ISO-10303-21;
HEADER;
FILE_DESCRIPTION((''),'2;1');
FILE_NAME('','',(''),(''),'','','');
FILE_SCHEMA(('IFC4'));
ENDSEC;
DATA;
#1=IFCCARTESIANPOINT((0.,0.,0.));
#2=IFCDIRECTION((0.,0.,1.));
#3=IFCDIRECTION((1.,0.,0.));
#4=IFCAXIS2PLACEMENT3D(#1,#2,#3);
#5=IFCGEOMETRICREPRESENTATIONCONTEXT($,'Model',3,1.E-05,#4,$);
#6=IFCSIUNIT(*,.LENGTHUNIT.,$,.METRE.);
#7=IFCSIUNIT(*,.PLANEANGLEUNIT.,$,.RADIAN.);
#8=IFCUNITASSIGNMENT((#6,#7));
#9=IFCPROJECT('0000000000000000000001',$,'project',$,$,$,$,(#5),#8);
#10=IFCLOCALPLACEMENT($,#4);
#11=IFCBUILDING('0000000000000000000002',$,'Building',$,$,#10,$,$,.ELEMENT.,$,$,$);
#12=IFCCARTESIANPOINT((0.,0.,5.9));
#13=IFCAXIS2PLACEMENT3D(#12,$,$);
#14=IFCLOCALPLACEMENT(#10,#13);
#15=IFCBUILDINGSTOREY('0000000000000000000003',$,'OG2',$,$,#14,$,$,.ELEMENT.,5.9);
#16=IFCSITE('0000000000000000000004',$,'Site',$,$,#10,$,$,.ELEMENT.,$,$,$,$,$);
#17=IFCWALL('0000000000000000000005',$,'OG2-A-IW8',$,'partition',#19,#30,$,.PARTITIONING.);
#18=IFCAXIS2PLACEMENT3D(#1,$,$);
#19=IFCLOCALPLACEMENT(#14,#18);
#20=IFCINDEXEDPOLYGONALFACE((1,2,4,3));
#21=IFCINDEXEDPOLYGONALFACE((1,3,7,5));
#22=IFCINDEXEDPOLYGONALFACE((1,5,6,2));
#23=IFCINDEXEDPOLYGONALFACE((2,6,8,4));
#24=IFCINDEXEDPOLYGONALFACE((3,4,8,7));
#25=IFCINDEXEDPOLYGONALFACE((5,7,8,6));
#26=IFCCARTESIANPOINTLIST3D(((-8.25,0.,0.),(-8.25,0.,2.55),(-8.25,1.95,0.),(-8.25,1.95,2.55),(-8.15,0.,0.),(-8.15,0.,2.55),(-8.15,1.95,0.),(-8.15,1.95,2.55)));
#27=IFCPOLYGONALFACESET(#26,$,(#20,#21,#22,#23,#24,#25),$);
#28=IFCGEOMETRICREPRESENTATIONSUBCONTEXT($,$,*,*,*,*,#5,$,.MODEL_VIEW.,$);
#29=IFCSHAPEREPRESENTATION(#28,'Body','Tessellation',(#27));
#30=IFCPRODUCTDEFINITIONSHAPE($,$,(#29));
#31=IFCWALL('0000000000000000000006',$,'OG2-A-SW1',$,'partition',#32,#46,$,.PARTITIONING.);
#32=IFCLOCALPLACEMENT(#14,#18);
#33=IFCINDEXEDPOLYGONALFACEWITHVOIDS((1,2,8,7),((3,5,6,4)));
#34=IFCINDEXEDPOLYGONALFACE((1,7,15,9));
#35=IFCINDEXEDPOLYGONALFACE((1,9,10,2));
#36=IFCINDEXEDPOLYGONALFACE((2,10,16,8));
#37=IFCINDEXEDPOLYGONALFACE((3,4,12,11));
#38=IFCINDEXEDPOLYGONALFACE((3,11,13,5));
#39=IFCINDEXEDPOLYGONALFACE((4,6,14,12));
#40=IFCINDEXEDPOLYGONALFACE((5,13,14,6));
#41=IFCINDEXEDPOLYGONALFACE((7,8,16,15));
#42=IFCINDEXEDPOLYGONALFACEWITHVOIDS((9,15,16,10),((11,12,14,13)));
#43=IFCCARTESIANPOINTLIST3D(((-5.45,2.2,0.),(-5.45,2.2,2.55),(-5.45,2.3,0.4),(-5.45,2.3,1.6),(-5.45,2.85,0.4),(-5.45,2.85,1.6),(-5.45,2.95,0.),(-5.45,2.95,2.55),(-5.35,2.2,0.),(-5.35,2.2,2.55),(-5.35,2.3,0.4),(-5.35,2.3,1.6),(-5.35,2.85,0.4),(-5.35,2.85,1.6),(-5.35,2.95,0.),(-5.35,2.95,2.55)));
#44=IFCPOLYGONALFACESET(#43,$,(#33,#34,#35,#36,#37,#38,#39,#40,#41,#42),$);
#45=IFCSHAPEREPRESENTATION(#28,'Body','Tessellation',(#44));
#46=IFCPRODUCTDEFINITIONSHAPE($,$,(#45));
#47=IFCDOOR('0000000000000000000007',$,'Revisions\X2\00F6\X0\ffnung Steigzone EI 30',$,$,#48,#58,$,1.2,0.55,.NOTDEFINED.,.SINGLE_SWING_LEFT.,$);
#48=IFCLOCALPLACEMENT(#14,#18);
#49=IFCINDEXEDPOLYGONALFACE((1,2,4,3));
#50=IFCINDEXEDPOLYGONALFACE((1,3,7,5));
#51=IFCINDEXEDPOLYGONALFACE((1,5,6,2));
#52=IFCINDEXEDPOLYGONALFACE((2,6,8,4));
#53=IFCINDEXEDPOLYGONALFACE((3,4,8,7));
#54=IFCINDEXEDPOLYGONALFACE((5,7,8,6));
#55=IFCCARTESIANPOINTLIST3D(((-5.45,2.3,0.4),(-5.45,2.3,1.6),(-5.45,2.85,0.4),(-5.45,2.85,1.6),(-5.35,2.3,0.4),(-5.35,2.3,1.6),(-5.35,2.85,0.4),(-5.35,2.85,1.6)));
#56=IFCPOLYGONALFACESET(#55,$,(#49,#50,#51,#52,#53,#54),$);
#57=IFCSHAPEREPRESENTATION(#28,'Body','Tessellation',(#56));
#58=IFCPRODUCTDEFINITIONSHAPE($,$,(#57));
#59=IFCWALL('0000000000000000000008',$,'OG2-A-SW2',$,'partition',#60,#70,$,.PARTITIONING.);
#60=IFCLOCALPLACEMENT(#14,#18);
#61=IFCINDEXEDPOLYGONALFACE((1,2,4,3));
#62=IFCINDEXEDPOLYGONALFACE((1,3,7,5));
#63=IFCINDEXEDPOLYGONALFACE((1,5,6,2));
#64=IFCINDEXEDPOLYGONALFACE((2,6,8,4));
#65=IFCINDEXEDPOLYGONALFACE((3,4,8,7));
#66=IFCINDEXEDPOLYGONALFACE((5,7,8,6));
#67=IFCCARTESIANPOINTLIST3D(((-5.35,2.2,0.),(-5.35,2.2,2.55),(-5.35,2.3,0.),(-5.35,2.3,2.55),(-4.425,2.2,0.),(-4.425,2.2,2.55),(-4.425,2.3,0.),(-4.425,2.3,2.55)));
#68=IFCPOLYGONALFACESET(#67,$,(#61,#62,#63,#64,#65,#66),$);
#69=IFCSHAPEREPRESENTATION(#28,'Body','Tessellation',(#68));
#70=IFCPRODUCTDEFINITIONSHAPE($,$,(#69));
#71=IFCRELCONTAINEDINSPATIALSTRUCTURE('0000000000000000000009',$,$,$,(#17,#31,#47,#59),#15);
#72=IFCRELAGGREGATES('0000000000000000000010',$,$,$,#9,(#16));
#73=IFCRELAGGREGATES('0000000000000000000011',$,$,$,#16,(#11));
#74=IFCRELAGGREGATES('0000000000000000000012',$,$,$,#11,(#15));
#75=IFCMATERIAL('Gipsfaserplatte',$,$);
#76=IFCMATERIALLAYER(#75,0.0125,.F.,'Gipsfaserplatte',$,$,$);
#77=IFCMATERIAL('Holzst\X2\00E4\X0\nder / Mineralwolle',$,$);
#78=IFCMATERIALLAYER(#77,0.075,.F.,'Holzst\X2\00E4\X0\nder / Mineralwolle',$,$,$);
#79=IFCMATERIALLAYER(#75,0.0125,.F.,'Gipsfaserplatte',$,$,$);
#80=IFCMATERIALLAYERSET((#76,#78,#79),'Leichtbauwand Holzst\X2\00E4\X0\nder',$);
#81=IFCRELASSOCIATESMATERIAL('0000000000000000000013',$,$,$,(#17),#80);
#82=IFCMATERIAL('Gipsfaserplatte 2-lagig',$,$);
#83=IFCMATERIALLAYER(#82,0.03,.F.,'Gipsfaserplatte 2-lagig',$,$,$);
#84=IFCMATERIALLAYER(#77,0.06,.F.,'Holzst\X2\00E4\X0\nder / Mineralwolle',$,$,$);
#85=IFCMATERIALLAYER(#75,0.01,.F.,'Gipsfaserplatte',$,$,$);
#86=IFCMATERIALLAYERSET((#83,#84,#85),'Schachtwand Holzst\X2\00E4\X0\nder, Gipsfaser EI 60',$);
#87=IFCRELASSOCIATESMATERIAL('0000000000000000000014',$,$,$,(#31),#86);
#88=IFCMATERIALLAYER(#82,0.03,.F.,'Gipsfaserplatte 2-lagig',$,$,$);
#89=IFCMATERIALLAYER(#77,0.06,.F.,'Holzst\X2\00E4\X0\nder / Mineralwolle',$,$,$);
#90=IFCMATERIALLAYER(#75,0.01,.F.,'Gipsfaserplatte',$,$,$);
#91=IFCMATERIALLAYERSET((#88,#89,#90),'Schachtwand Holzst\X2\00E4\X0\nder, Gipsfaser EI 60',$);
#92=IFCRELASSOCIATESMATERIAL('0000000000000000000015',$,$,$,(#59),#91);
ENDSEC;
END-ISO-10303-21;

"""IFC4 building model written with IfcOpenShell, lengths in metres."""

from ifc_helpers import new_model, si_unit, frame, frame_2d, origin, origin_with_axes, place, context, subcontext, project, spatial, rectangle, extrude, material, layer, layer_set, element, fill, save


model = new_model("IFC4")

# Units and contexts
model_context = context("Model", 3, precision=1e-05, world=origin_with_axes())
sub_context = subcontext(model_context, None, None, "MODEL_VIEW")
ifc_project = project(units=[si_unit("LENGTHUNIT", "METRE"), si_unit("PLANEANGLEUNIT", "RADIAN")], contexts=[model_context])

# Site, building, storey
placement = place(None, origin_with_axes())
site = spatial("IfcSite", under=ifc_project, at=placement, Name="Site", CompositionType="ELEMENT")
building = spatial("IfcBuilding", under=site, at=placement, Name="Building", CompositionType="ELEMENT")
storey_placement = place(placement, frame((0.0, 0.0, 5.9)))
storey = spatial("IfcBuildingStorey", under=building, at=storey_placement, Name="OG2", CompositionType="ELEMENT", Elevation=5.9)

# Shared definitions
ifc_material_1 = material(Name="Gipsfaserplatte")

# Shared definitions
ifc_material_2 = material(Name="Gipsfaserplatte 2-lagig")

# Shared definitions
ifc_material_3 = material(Name="Holzständer / Mineralwolle")

# Wall
ifc_layer_1 = layer(ifc_material_1, 0.0125, ventilated=False, Name="Gipsfaserplatte")
ifc_layer_2 = layer(ifc_material_3, 0.075, ventilated=False, Name="Holzständer / Mineralwolle")
ifc_layer_3 = layer(ifc_material_1, 0.0125, ventilated=False, Name="Gipsfaserplatte")
ifc_layer_set_1 = layer_set([ifc_layer_1, ifc_layer_2, ifc_layer_3], Name="Leichtbauwand Holzständer")
wall_1_placement = place(storey_placement, frame((-8.2, 0.0, 0.0), z_axis=(0.0, 0.0, 1.0), x_axis=(0.0, 1.0, 0.0)))
element("IfcWall", 1, at=wall_1_placement, inside=storey, material=ifc_layer_set_1, Name="OG2-A-IW8", ObjectType="partition", PredefinedType="PARTITIONING", context=sub_context, shape_type="SweptSolid", body=[
    extrude(rectangle(XDim=1.95, YDim=0.1, at=frame_2d((0.975, 0.0))), origin(), (0.0, 0.0, 1.0), 2.55),
])

# Wall, opening, door
ifc_layer_4 = layer(ifc_material_2, 0.03, ventilated=False, Name="Gipsfaserplatte 2-lagig")
ifc_layer_5 = layer(ifc_material_3, 0.06, ventilated=False, Name="Holzständer / Mineralwolle")
ifc_layer_6 = layer(ifc_material_1, 0.01, ventilated=False, Name="Gipsfaserplatte")
ifc_layer_set_2 = layer_set([ifc_layer_4, ifc_layer_5, ifc_layer_6], Name="Schachtwand Holzständer, Gipsfaser EI 60")
wall_2_placement = place(storey_placement, frame((-5.4, 2.2, 0.0), z_axis=(0.0, 0.0, 1.0), x_axis=(0.0, 1.0, 0.0)))
wall_2 = element("IfcWall", 2, at=wall_2_placement, inside=storey, material=ifc_layer_set_2, Name="OG2-A-SW1", ObjectType="partition", PredefinedType="PARTITIONING", context=sub_context, shape_type="SweptSolid", body=[
    extrude(rectangle(XDim=0.75, YDim=0.1, at=frame_2d((0.375, 0.0))), origin(), (0.0, 0.0, 1.0), 2.55),
])
opening_1_placement = place(wall_2_placement, frame((0.375, 0.1, 0.4), z_axis=(0.0, -1.0, 0.0), x_axis=(1.0, 0.0, 0.0)))
opening_1 = element("IfcOpeningElement", 3, at=opening_1_placement, cuts=wall_2, PredefinedType="OPENING", context=sub_context, shape_type="SweptSolid", body=[
    extrude(rectangle(XDim=0.55, YDim=1.2, at=frame_2d((0.0, 0.6))), origin(), (0.0, 0.0, 1.0), 0.2),
])
door_1_placement = place(wall_2_placement, frame((0.375, 0.05, 0.4), z_axis=(0.0, -1.0, 0.0), x_axis=(1.0, 0.0, 0.0)))
door_1 = element("IfcDoor", 4, at=door_1_placement, inside=storey, Name="Revisionsöffnung Steigzone EI 30", OperationType="SINGLE_SWING_LEFT", OverallHeight=1.2, OverallWidth=0.55, PredefinedType="NOTDEFINED", context=sub_context, shape_type="SweptSolid", body=[
    extrude(rectangle(XDim=0.55, YDim=1.2, at=frame_2d((0.0, 0.6))), origin(), (0.0, 0.0, 1.0), 0.1),
])
fill(opening_1, door_1)

# Wall
ifc_layer_7 = layer(ifc_material_2, 0.03, ventilated=False, Name="Gipsfaserplatte 2-lagig")
ifc_layer_8 = layer(ifc_material_3, 0.06, ventilated=False, Name="Holzständer / Mineralwolle")
ifc_layer_9 = layer(ifc_material_1, 0.01, ventilated=False, Name="Gipsfaserplatte")
ifc_layer_set_3 = layer_set([ifc_layer_7, ifc_layer_8, ifc_layer_9], Name="Schachtwand Holzständer, Gipsfaser EI 60")
wall_3_placement = place(storey_placement, frame((-5.35, 2.25, 0.0), z_axis=(0.0, 0.0, 1.0), x_axis=(1.0, 0.0, 0.0)))
element("IfcWall", 5, at=wall_3_placement, inside=storey, material=ifc_layer_set_3, Name="OG2-A-SW2", ObjectType="partition", PredefinedType="PARTITIONING", context=sub_context, shape_type="SweptSolid", body=[
    extrude(rectangle(XDim=0.925, YDim=0.1, at=frame_2d((0.4625, 0.0))), origin(), (0.0, 0.0, 1.0), 2.55),
])

save(model, "model.ifc")
